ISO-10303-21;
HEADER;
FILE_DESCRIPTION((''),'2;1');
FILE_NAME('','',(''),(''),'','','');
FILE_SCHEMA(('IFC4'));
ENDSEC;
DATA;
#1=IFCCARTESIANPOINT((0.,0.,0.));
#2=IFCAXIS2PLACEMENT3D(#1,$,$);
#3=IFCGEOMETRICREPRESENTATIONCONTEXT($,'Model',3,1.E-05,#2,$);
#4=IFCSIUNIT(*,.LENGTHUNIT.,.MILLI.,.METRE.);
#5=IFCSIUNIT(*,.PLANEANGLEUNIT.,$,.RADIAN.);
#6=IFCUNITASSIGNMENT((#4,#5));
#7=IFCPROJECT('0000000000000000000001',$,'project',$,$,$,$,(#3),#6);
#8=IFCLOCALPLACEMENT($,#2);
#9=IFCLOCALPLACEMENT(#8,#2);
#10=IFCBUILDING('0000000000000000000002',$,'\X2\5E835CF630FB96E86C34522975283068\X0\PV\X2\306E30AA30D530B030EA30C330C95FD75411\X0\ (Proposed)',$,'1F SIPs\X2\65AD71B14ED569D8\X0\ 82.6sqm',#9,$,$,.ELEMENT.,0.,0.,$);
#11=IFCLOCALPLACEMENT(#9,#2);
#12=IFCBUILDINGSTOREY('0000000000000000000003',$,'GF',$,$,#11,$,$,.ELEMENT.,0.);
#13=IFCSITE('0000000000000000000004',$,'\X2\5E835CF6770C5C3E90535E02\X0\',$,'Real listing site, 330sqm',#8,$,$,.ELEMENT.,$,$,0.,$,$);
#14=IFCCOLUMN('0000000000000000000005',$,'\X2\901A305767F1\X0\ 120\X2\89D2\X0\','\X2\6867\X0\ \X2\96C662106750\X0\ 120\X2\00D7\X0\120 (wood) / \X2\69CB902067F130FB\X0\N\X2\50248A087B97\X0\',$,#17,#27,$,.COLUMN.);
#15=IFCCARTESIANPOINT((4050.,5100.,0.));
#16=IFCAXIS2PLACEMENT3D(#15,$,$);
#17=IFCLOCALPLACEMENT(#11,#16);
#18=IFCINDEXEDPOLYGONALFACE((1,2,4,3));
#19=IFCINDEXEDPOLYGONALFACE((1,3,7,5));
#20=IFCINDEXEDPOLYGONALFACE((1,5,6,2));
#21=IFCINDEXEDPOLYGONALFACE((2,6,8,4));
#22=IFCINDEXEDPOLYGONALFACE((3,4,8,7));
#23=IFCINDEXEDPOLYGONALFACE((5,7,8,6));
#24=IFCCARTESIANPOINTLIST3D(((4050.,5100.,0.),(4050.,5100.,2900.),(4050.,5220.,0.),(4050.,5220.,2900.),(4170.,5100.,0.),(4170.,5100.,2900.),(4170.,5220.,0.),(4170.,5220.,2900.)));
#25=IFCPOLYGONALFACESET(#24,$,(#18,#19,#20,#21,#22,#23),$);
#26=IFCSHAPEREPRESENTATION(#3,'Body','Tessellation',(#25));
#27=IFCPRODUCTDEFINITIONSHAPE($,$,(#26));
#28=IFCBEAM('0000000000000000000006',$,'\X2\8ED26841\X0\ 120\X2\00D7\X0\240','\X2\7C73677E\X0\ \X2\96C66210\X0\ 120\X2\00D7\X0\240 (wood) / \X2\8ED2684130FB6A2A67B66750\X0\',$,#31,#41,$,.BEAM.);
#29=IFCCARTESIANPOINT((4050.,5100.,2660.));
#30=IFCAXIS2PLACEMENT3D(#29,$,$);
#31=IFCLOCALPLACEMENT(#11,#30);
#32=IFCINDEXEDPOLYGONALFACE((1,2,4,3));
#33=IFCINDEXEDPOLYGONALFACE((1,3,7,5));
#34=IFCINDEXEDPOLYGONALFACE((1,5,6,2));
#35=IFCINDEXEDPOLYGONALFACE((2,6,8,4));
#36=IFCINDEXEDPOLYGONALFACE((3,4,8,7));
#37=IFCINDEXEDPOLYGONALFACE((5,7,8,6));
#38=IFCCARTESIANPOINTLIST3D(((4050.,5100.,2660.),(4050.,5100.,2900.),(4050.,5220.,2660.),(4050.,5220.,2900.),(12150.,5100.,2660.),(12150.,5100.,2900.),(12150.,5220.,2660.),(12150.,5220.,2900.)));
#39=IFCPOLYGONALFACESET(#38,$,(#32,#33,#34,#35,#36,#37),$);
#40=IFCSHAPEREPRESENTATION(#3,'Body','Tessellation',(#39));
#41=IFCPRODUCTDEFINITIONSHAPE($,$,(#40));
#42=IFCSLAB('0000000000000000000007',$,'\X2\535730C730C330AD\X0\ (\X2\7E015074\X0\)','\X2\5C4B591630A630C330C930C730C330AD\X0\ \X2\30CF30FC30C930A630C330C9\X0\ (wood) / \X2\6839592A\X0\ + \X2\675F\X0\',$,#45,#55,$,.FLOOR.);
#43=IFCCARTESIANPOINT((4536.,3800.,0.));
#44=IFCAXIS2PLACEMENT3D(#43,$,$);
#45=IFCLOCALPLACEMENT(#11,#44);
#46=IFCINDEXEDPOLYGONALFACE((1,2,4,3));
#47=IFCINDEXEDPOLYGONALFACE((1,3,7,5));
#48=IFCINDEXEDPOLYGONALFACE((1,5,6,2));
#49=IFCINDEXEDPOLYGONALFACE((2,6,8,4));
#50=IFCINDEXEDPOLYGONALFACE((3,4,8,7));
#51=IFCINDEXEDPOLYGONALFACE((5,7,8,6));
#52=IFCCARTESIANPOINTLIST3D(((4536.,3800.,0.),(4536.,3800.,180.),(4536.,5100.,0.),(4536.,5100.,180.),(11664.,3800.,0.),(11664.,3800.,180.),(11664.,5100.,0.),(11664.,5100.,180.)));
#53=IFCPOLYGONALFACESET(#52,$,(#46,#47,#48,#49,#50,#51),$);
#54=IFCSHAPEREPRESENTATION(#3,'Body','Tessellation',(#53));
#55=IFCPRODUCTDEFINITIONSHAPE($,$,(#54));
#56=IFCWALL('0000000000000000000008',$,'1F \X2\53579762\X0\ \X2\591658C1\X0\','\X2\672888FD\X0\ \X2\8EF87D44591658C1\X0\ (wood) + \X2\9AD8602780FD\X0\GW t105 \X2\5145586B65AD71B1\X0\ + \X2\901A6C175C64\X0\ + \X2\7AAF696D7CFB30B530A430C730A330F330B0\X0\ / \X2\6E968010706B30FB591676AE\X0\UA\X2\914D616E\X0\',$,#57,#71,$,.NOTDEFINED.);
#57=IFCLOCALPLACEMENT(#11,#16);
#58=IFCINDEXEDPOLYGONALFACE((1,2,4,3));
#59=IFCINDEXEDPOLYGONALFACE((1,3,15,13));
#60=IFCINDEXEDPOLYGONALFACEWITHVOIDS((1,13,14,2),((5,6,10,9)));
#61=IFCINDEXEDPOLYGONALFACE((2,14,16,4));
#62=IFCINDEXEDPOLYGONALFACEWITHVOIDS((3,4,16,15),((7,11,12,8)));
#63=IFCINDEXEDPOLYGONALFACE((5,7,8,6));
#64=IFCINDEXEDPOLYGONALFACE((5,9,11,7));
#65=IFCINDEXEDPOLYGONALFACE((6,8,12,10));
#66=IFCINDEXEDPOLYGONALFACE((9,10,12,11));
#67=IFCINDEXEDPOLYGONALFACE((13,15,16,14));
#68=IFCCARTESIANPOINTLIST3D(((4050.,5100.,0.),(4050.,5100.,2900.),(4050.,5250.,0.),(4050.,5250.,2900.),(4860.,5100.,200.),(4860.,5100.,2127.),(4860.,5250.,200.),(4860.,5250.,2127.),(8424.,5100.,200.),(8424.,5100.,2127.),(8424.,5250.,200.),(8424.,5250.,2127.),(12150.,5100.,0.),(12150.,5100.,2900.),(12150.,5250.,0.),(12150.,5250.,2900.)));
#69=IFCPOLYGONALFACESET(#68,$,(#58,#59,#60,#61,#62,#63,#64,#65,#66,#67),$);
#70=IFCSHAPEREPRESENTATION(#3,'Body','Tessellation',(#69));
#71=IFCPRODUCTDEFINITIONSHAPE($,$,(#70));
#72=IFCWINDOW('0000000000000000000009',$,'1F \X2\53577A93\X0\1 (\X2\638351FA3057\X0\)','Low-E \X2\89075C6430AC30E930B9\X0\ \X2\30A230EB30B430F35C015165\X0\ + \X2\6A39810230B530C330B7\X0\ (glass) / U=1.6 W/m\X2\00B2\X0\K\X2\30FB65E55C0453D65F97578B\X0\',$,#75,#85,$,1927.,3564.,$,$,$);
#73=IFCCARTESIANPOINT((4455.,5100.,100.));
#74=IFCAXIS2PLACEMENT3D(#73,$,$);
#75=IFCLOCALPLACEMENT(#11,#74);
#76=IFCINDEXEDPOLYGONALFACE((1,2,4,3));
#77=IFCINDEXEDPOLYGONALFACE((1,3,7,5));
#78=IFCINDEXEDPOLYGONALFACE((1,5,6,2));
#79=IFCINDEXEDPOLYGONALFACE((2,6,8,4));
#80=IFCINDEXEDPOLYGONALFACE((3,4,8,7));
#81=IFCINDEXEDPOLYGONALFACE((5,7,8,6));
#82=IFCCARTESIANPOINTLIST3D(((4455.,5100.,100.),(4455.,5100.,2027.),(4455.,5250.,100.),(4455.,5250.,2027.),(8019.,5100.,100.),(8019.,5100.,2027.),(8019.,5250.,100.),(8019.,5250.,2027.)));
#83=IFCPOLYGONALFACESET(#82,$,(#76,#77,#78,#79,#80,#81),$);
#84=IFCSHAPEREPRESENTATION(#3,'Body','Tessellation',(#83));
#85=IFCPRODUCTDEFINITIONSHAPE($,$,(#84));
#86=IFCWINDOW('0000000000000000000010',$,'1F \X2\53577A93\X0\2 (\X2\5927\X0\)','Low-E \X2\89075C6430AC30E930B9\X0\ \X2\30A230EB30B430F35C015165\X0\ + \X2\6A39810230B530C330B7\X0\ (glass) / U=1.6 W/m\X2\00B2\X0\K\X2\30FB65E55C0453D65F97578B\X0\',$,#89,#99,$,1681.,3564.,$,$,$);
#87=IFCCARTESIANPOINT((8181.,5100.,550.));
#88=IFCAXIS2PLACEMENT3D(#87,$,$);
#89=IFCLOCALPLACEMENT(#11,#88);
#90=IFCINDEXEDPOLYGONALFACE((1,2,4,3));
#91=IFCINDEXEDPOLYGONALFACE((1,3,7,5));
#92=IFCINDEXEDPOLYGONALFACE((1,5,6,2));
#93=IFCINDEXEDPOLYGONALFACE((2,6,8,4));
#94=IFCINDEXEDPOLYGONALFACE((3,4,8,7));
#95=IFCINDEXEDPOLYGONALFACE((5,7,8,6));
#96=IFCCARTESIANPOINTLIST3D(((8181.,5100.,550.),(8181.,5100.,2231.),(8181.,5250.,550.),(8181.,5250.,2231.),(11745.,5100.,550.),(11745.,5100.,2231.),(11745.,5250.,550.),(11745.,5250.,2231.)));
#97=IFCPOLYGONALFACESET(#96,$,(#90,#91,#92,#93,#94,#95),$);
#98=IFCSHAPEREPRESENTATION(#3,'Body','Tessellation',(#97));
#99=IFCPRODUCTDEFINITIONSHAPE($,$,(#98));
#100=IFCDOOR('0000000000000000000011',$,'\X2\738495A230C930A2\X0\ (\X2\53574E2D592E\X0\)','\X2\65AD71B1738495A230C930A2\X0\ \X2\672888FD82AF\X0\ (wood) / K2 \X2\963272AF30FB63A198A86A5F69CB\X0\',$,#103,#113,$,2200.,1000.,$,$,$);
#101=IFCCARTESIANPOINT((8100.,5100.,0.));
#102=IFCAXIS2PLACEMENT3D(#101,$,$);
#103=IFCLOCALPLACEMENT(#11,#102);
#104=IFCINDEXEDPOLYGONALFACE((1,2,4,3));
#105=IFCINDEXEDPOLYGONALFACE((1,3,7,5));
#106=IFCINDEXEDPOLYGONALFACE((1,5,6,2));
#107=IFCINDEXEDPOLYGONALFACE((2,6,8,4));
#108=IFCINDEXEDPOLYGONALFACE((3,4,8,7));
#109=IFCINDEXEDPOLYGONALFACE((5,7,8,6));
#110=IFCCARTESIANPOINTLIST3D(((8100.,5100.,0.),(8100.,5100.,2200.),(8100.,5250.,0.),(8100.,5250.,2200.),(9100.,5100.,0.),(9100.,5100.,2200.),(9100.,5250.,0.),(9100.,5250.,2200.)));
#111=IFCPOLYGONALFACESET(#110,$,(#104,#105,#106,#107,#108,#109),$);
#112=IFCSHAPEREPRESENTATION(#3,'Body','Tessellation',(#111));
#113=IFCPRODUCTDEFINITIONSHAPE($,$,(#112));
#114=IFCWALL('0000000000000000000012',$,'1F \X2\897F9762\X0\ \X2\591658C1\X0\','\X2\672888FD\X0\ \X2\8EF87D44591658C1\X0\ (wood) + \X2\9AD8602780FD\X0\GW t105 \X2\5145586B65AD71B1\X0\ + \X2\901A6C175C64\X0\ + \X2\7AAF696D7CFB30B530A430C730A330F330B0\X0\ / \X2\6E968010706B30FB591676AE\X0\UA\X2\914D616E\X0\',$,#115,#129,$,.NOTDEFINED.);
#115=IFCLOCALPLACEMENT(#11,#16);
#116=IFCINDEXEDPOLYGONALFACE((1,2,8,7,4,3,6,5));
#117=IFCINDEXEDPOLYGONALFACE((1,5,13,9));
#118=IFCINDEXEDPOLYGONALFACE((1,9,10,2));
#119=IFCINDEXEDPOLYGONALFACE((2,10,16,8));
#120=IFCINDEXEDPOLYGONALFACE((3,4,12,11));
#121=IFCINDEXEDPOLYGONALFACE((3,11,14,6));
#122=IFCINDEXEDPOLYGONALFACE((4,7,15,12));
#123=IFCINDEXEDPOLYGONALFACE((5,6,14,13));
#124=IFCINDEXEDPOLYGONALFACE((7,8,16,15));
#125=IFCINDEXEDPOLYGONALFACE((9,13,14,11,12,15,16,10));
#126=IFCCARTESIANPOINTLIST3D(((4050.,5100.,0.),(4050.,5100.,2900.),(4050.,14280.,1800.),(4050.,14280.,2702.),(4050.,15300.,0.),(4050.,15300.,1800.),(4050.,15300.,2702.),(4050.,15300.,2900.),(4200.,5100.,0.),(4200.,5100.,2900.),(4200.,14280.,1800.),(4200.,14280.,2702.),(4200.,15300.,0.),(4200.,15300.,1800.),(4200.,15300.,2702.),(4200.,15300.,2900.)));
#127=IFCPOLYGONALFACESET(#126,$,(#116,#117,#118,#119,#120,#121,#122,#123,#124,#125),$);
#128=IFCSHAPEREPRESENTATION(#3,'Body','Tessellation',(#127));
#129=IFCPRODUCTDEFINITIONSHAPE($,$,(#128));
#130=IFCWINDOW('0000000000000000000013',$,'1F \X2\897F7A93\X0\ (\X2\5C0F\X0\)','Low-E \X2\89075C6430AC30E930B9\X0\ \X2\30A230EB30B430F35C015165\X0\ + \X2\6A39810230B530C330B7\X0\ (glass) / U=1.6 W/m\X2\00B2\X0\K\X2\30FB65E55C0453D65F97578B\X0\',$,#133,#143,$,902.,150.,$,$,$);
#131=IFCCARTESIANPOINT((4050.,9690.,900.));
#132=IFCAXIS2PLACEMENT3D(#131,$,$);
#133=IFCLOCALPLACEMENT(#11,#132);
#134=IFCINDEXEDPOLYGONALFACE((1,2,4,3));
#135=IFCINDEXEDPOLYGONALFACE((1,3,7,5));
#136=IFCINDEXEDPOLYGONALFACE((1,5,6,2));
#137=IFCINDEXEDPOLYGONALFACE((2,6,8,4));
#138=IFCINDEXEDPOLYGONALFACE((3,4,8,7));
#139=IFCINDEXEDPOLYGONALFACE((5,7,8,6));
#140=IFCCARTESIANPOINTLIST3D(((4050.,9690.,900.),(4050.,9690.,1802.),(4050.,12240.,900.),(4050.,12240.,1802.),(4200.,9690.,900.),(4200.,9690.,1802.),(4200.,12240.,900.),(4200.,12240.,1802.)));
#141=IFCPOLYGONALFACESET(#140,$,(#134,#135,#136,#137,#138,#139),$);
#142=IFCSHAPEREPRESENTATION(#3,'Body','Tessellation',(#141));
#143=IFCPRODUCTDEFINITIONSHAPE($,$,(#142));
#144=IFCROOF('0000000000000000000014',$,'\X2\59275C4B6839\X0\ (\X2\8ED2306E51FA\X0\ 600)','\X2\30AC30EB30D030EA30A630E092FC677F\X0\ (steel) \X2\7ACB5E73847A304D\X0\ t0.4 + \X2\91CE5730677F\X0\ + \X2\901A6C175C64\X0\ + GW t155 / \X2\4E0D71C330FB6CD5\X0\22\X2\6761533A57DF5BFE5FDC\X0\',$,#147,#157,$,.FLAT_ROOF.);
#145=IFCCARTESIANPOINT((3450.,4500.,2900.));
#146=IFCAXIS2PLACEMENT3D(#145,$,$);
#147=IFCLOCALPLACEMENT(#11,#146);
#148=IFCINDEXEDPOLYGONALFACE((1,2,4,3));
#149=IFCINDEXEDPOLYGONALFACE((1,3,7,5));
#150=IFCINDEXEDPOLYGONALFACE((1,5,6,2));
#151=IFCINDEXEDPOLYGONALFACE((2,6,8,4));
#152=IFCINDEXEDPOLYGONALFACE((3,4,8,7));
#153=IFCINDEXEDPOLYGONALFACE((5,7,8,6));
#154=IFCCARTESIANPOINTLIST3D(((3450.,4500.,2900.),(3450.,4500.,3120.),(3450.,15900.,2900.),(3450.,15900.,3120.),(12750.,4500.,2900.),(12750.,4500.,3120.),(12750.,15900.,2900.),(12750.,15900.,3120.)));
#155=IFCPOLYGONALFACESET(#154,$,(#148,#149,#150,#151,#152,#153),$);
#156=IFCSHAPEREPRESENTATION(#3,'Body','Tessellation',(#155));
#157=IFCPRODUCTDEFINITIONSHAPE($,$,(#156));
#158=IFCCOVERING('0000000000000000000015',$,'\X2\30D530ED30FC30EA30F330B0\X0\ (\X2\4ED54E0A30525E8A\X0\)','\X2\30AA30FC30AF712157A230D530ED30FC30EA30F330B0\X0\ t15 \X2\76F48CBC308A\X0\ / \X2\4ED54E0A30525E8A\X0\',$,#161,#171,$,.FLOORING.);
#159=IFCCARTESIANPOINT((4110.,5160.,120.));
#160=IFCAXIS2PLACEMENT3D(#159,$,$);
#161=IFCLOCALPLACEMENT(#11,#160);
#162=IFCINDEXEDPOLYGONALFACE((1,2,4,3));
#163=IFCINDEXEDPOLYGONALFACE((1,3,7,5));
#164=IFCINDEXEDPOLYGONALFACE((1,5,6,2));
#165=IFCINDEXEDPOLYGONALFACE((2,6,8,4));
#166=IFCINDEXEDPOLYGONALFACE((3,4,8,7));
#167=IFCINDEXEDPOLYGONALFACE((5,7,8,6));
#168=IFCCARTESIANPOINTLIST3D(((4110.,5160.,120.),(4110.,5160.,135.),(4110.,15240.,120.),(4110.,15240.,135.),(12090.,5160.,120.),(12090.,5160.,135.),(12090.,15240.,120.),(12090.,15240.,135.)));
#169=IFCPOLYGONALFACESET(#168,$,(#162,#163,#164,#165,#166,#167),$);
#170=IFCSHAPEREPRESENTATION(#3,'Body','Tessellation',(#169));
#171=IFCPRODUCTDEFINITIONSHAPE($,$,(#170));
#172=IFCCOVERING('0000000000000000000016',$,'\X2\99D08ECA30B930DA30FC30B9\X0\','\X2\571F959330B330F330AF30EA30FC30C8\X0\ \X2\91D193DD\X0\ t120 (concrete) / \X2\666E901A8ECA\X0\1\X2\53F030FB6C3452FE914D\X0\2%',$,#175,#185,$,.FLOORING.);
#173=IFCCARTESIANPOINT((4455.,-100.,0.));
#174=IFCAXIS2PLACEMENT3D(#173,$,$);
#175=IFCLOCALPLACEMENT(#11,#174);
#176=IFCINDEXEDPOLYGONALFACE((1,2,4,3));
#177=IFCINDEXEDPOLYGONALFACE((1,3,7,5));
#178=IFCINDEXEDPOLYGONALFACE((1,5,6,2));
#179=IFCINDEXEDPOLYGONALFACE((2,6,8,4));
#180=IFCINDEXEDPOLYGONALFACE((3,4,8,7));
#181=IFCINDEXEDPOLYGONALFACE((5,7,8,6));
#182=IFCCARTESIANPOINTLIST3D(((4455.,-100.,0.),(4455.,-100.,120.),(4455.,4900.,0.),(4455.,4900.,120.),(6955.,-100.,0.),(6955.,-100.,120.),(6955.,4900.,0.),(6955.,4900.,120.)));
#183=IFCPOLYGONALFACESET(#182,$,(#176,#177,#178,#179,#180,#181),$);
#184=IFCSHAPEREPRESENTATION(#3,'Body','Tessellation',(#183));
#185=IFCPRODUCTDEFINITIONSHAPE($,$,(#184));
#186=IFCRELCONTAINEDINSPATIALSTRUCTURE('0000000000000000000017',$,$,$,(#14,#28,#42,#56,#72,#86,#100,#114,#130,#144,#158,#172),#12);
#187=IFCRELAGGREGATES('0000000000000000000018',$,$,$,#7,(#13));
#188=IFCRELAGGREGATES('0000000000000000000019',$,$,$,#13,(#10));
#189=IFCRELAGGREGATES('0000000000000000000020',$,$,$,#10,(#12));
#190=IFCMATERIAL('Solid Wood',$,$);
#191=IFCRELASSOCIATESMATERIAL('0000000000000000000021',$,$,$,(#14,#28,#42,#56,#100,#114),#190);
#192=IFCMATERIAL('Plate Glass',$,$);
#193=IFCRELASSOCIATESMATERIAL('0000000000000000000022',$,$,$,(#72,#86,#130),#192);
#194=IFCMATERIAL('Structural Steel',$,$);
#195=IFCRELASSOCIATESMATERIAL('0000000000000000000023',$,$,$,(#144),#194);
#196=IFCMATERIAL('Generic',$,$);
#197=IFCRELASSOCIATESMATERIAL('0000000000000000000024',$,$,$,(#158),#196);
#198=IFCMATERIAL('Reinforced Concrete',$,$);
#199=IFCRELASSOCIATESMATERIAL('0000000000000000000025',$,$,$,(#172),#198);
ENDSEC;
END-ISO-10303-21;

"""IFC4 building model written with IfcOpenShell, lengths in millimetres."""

from ifc_helpers import new_model, si_unit, frame, frame_2d, origin, place, context, project, spatial, rectangle, extrude, material, element, fill, save


model = new_model("IFC4")

# Units and contexts
model_context = context("Model", 3, precision=1e-05, world=origin())
ifc_project = project(units=[si_unit("LENGTHUNIT", "METRE", prefix="MILLI"), si_unit("PLANEANGLEUNIT", "RADIAN")], contexts=[model_context])

# Site, building, storey
site_placement = place(None, origin())
site = spatial("IfcSite", under=ifc_project, at=site_placement, Name="広島県尾道市", ObjectType="Real listing site, 330sqm", CompositionType="ELEMENT", RefElevation=0.0)
building_placement = place(site_placement, origin())
building = spatial("IfcBuilding", under=site, at=building_placement, Name="広島・雨水利用とPVのオフグリッド志向 (Proposed)", ObjectType="1F SIPs断熱仕様 82.6sqm", CompositionType="ELEMENT", ElevationOfRefHeight=0.0, ElevationOfTerrain=0.0)
storey_placement = place(building_placement, origin())
storey = spatial("IfcBuildingStorey", under=building, at=storey_placement, Name="GF", CompositionType="ELEMENT", Elevation=0.0)

# Column
ifc_material_1 = material(Name="Solid Wood")
column_placement = place(storey_placement, frame((4050.0, 5100.0, 0.0)))
element("IfcColumn", 1, at=column_placement, inside=storey, material=ifc_material_1, Name="通し柱 120角", Description="桧 集成材 120×120 (wood) / 構造柱・N値計算", PredefinedType="COLUMN", context=model_context, shape_type="SweptSolid", body=[
    extrude(rectangle(XDim=120.0, YDim=120.0, at=frame_2d((60.0, 60.0))), frame((4050.0, 5100.0, 0.0)), (0.0, 0.0, 1.0), 2900.0),
])

# Beam
beam_1_placement = place(storey_placement, frame((4050.0, 5100.0, 2660.0)))
element("IfcBeam", 2, at=beam_1_placement, inside=storey, material=ifc_material_1, Name="軒桁 120×240", Description="米松 集成 120×240 (wood) / 軒桁・横架材", PredefinedType="BEAM", context=model_context, shape_type="SweptSolid", body=[
    extrude(rectangle(XDim=8100.0, YDim=120.0, at=frame_2d((4050.0, 60.0))), frame((4050.0, 5100.0, 2660.0)), (0.0, 0.0, 1.0), 240.0),
])

# Slab
ifc_material_2 = material(Name="Reinforced Concrete")
slab_1_placement = place(storey_placement, frame((4536.0, 3800.0, 0.0)))
element("IfcSlab", 3, at=slab_1_placement, inside=storey, material=ifc_material_1, Name="南デッキ (縁側)", Description="屋外ウッドデッキ ハードウッド (wood) / 根太 + 束", PredefinedType="FLOOR", context=model_context, shape_type="SweptSolid", body=[
    extrude(rectangle(XDim=7128.0, YDim=1300.0, at=frame_2d((3564.0, 650.0))), frame((4536.0, 3800.0, 0.0)), (0.0, 0.0, 1.0), 180.0),
])

# Wall, openings, windows, door
wall_1_placement = place(storey_placement, frame((4050.0, 5100.0, 0.0)))
wall_1 = element("IfcWall", 4, at=wall_1_placement, inside=storey, material=ifc_material_1, Name="1F 南面 外壁", Description="木製 軸組外壁 (wood) + 高性能GW t105 充填断熱 + 通気層 + 窯業系サイディング / 準耐火・外皮UA配慮", PredefinedType="NOTDEFINED", context=model_context, shape_type="SweptSolid", body=[
    extrude(rectangle(XDim=8100.0, YDim=150.0, at=frame_2d((4050.0, 75.0))), frame((4050.0, 5100.0, 0.0)), (0.0, 0.0, 1.0), 2900.0),
])
opening_1_placement = place(storey_placement, frame((4455.0, 5100.0, 100.0)))
opening_1 = element("IfcOpeningElement", 5, at=opening_1_placement, cuts=wall_1, PredefinedType="NOTDEFINED", context=model_context, shape_type="SweptSolid", body=[
    extrude(rectangle(XDim=3564.0, YDim=150.0, at=frame_2d((1782.0, 75.0))), frame((4455.0, 5100.0, 100.0)), (0.0, 0.0, 1.0), 1927.0),
])
opening_2_placement = place(storey_placement, frame((8181.0, 5100.0, 550.0)))
opening_2 = element("IfcOpeningElement", 6, at=opening_2_placement, cuts=wall_1, PredefinedType="NOTDEFINED", context=model_context, shape_type="SweptSolid", body=[
    extrude(rectangle(XDim=3564.0, YDim=150.0, at=frame_2d((1782.0, 75.0))), frame((8181.0, 5100.0, 550.0)), (0.0, 0.0, 1.0), 1681.0),
])
opening_3_placement = place(storey_placement, frame((8100.0, 5100.0, 0.0)))
opening_3 = element("IfcOpeningElement", 7, at=opening_3_placement, cuts=wall_1, PredefinedType="NOTDEFINED", context=model_context, shape_type="SweptSolid", body=[
    extrude(rectangle(XDim=1000.0, YDim=150.0, at=frame_2d((500.0, 75.0))), frame((8100.0, 5100.0, 0.0)), (0.0, 0.0, 1.0), 2200.0),
])
ifc_material_3 = material(Name="Plate Glass")
window_1_placement = place(storey_placement, frame((4455.0, 5100.0, 100.0)))
window_1 = element("IfcWindow", 8, at=window_1_placement, inside=storey, material=ifc_material_3, Name="1F 南窓1 (掃出し)", Description="Low-E 複層ガラス アルゴン封入 + 樹脂サッシ (glass) / U=1.6 W/m²K・日射取得型", OverallHeight=1927.0, OverallWidth=3564.0, context=model_context, shape_type="SweptSolid", body=[
    extrude(rectangle(XDim=3564.0, YDim=150.0, at=frame_2d((1782.0, 75.0))), frame((4455.0, 5100.0, 100.0)), (0.0, 0.0, 1.0), 1927.0),
])
fill(opening_1, window_1)
window_2_placement = place(storey_placement, frame((8181.0, 5100.0, 550.0)))
window_2 = element("IfcWindow", 9, at=window_2_placement, inside=storey, material=ifc_material_3, Name="1F 南窓2 (大)", Description="Low-E 複層ガラス アルゴン封入 + 樹脂サッシ (glass) / U=1.6 W/m²K・日射取得型", OverallHeight=1681.0, OverallWidth=3564.0, context=model_context, shape_type="SweptSolid", body=[
    extrude(rectangle(XDim=3564.0, YDim=150.0, at=frame_2d((1782.0, 75.0))), frame((8181.0, 5100.0, 550.0)), (0.0, 0.0, 1.0), 1681.0),
])
fill(opening_2, window_2)
door_placement = place(storey_placement, frame((8100.0, 5100.0, 0.0)))
door = element("IfcDoor", 10, at=door_placement, inside=storey, material=ifc_material_1, Name="玄関ドア (南中央)", Description="断熱玄関ドア 木製芯 (wood) / K2 防犯・採風機構", OverallHeight=2200.0, OverallWidth=1000.0, context=model_context, shape_type="SweptSolid", body=[
    extrude(rectangle(XDim=1000.0, YDim=150.0, at=frame_2d((500.0, 75.0))), frame((8100.0, 5100.0, 0.0)), (0.0, 0.0, 1.0), 2200.0),
])
fill(opening_3, door)

# Wall, opening, window
wall_2_placement = place(storey_placement, frame((4050.0, 5100.0, 0.0)))
wall_2 = element("IfcWall", 11, at=wall_2_placement, inside=storey, material=ifc_material_1, Name="1F 西面 外壁", Description="木製 軸組外壁 (wood) + 高性能GW t105 充填断熱 + 通気層 + 窯業系サイディング / 準耐火・外皮UA配慮", PredefinedType="NOTDEFINED", context=model_context, shape_type="SweptSolid", body=[
    extrude(rectangle(XDim=150.0, YDim=10200.0, at=frame_2d((75.0, 5100.0))), frame((4050.0, 5100.0, 0.0)), (0.0, 0.0, 1.0), 2900.0),
])
opening_4_placement = place(storey_placement, frame((4050.0, 9690.0, 900.0)))
opening_4 = element("IfcOpeningElement", 12, at=opening_4_placement, cuts=wall_2, PredefinedType="NOTDEFINED", context=model_context, shape_type="SweptSolid", body=[
    extrude(rectangle(XDim=150.0, YDim=2550.0, at=frame_2d((75.0, 1275.0))), frame((4050.0, 9690.0, 900.0)), (0.0, 0.0, 1.0), 902.0),
])
window_3_placement = place(storey_placement, frame((4050.0, 9690.0, 900.0)))
window_3 = element("IfcWindow", 13, at=window_3_placement, inside=storey, material=ifc_material_3, Name="1F 西窓 (小)", Description="Low-E 複層ガラス アルゴン封入 + 樹脂サッシ (glass) / U=1.6 W/m²K・日射取得型", OverallHeight=902.0, OverallWidth=150.0, context=model_context, shape_type="SweptSolid", body=[
    extrude(rectangle(XDim=150.0, YDim=2550.0, at=frame_2d((75.0, 1275.0))), frame((4050.0, 9690.0, 900.0)), (0.0, 0.0, 1.0), 902.0),
])
fill(opening_4, window_3)

# Roof
ifc_material_4 = material(Name="Structural Steel")
roof_placement = place(storey_placement, frame((3450.0, 4500.0, 2900.0)))
element("IfcRoof", 14, at=roof_placement, inside=storey, material=ifc_material_4, Name="大屋根 (軒の出 600)", Description="ガルバリウム鋼板 (steel) 立平葺き t0.4 + 野地板 + 通気層 + GW t155 / 不燃・法22条区域対応", PredefinedType="FLAT_ROOF", context=model_context, shape_type="SweptSolid", body=[
    extrude(rectangle(XDim=9300.0, YDim=11400.0, at=frame_2d((4650.0, 5700.0))), frame((3450.0, 4500.0, 2900.0)), (0.0, 0.0, 1.0), 220.0),
])

# Coverings
ifc_material_5 = material(Name="Generic")
covering_1_placement = place(storey_placement, frame((4110.0, 5160.0, 120.0)))
element("IfcCovering", 15, at=covering_1_placement, inside=storey, material=ifc_material_5, Name="フローリング (仕上げ床)", Description="オーク無垢フローリング t15 直貼り / 仕上げ床", PredefinedType="FLOORING", context=model_context, shape_type="SweptSolid", body=[
    extrude(rectangle(XDim=7980.0, YDim=10080.0, at=frame_2d((3990.0, 5040.0))), frame((4110.0, 5160.0, 120.0)), (0.0, 0.0, 1.0), 15.0),
])
covering_2_placement = place(storey_placement, frame((4455.0, -100.0, 0.0)))
element("IfcCovering", 16, at=covering_2_placement, inside=storey, material=ifc_material_2, Name="駐車スペース", Description="土間コンクリート 金鏝 t120 (concrete) / 普通車1台・水勾配2%", PredefinedType="FLOORING", context=model_context, shape_type="SweptSolid", body=[
    extrude(rectangle(XDim=2500.0, YDim=5000.0, at=frame_2d((1250.0, 2500.0))), frame((4455.0, -100.0, 0.0)), (0.0, 0.0, 1.0), 120.0),
])

save(model, "model.ifc")
